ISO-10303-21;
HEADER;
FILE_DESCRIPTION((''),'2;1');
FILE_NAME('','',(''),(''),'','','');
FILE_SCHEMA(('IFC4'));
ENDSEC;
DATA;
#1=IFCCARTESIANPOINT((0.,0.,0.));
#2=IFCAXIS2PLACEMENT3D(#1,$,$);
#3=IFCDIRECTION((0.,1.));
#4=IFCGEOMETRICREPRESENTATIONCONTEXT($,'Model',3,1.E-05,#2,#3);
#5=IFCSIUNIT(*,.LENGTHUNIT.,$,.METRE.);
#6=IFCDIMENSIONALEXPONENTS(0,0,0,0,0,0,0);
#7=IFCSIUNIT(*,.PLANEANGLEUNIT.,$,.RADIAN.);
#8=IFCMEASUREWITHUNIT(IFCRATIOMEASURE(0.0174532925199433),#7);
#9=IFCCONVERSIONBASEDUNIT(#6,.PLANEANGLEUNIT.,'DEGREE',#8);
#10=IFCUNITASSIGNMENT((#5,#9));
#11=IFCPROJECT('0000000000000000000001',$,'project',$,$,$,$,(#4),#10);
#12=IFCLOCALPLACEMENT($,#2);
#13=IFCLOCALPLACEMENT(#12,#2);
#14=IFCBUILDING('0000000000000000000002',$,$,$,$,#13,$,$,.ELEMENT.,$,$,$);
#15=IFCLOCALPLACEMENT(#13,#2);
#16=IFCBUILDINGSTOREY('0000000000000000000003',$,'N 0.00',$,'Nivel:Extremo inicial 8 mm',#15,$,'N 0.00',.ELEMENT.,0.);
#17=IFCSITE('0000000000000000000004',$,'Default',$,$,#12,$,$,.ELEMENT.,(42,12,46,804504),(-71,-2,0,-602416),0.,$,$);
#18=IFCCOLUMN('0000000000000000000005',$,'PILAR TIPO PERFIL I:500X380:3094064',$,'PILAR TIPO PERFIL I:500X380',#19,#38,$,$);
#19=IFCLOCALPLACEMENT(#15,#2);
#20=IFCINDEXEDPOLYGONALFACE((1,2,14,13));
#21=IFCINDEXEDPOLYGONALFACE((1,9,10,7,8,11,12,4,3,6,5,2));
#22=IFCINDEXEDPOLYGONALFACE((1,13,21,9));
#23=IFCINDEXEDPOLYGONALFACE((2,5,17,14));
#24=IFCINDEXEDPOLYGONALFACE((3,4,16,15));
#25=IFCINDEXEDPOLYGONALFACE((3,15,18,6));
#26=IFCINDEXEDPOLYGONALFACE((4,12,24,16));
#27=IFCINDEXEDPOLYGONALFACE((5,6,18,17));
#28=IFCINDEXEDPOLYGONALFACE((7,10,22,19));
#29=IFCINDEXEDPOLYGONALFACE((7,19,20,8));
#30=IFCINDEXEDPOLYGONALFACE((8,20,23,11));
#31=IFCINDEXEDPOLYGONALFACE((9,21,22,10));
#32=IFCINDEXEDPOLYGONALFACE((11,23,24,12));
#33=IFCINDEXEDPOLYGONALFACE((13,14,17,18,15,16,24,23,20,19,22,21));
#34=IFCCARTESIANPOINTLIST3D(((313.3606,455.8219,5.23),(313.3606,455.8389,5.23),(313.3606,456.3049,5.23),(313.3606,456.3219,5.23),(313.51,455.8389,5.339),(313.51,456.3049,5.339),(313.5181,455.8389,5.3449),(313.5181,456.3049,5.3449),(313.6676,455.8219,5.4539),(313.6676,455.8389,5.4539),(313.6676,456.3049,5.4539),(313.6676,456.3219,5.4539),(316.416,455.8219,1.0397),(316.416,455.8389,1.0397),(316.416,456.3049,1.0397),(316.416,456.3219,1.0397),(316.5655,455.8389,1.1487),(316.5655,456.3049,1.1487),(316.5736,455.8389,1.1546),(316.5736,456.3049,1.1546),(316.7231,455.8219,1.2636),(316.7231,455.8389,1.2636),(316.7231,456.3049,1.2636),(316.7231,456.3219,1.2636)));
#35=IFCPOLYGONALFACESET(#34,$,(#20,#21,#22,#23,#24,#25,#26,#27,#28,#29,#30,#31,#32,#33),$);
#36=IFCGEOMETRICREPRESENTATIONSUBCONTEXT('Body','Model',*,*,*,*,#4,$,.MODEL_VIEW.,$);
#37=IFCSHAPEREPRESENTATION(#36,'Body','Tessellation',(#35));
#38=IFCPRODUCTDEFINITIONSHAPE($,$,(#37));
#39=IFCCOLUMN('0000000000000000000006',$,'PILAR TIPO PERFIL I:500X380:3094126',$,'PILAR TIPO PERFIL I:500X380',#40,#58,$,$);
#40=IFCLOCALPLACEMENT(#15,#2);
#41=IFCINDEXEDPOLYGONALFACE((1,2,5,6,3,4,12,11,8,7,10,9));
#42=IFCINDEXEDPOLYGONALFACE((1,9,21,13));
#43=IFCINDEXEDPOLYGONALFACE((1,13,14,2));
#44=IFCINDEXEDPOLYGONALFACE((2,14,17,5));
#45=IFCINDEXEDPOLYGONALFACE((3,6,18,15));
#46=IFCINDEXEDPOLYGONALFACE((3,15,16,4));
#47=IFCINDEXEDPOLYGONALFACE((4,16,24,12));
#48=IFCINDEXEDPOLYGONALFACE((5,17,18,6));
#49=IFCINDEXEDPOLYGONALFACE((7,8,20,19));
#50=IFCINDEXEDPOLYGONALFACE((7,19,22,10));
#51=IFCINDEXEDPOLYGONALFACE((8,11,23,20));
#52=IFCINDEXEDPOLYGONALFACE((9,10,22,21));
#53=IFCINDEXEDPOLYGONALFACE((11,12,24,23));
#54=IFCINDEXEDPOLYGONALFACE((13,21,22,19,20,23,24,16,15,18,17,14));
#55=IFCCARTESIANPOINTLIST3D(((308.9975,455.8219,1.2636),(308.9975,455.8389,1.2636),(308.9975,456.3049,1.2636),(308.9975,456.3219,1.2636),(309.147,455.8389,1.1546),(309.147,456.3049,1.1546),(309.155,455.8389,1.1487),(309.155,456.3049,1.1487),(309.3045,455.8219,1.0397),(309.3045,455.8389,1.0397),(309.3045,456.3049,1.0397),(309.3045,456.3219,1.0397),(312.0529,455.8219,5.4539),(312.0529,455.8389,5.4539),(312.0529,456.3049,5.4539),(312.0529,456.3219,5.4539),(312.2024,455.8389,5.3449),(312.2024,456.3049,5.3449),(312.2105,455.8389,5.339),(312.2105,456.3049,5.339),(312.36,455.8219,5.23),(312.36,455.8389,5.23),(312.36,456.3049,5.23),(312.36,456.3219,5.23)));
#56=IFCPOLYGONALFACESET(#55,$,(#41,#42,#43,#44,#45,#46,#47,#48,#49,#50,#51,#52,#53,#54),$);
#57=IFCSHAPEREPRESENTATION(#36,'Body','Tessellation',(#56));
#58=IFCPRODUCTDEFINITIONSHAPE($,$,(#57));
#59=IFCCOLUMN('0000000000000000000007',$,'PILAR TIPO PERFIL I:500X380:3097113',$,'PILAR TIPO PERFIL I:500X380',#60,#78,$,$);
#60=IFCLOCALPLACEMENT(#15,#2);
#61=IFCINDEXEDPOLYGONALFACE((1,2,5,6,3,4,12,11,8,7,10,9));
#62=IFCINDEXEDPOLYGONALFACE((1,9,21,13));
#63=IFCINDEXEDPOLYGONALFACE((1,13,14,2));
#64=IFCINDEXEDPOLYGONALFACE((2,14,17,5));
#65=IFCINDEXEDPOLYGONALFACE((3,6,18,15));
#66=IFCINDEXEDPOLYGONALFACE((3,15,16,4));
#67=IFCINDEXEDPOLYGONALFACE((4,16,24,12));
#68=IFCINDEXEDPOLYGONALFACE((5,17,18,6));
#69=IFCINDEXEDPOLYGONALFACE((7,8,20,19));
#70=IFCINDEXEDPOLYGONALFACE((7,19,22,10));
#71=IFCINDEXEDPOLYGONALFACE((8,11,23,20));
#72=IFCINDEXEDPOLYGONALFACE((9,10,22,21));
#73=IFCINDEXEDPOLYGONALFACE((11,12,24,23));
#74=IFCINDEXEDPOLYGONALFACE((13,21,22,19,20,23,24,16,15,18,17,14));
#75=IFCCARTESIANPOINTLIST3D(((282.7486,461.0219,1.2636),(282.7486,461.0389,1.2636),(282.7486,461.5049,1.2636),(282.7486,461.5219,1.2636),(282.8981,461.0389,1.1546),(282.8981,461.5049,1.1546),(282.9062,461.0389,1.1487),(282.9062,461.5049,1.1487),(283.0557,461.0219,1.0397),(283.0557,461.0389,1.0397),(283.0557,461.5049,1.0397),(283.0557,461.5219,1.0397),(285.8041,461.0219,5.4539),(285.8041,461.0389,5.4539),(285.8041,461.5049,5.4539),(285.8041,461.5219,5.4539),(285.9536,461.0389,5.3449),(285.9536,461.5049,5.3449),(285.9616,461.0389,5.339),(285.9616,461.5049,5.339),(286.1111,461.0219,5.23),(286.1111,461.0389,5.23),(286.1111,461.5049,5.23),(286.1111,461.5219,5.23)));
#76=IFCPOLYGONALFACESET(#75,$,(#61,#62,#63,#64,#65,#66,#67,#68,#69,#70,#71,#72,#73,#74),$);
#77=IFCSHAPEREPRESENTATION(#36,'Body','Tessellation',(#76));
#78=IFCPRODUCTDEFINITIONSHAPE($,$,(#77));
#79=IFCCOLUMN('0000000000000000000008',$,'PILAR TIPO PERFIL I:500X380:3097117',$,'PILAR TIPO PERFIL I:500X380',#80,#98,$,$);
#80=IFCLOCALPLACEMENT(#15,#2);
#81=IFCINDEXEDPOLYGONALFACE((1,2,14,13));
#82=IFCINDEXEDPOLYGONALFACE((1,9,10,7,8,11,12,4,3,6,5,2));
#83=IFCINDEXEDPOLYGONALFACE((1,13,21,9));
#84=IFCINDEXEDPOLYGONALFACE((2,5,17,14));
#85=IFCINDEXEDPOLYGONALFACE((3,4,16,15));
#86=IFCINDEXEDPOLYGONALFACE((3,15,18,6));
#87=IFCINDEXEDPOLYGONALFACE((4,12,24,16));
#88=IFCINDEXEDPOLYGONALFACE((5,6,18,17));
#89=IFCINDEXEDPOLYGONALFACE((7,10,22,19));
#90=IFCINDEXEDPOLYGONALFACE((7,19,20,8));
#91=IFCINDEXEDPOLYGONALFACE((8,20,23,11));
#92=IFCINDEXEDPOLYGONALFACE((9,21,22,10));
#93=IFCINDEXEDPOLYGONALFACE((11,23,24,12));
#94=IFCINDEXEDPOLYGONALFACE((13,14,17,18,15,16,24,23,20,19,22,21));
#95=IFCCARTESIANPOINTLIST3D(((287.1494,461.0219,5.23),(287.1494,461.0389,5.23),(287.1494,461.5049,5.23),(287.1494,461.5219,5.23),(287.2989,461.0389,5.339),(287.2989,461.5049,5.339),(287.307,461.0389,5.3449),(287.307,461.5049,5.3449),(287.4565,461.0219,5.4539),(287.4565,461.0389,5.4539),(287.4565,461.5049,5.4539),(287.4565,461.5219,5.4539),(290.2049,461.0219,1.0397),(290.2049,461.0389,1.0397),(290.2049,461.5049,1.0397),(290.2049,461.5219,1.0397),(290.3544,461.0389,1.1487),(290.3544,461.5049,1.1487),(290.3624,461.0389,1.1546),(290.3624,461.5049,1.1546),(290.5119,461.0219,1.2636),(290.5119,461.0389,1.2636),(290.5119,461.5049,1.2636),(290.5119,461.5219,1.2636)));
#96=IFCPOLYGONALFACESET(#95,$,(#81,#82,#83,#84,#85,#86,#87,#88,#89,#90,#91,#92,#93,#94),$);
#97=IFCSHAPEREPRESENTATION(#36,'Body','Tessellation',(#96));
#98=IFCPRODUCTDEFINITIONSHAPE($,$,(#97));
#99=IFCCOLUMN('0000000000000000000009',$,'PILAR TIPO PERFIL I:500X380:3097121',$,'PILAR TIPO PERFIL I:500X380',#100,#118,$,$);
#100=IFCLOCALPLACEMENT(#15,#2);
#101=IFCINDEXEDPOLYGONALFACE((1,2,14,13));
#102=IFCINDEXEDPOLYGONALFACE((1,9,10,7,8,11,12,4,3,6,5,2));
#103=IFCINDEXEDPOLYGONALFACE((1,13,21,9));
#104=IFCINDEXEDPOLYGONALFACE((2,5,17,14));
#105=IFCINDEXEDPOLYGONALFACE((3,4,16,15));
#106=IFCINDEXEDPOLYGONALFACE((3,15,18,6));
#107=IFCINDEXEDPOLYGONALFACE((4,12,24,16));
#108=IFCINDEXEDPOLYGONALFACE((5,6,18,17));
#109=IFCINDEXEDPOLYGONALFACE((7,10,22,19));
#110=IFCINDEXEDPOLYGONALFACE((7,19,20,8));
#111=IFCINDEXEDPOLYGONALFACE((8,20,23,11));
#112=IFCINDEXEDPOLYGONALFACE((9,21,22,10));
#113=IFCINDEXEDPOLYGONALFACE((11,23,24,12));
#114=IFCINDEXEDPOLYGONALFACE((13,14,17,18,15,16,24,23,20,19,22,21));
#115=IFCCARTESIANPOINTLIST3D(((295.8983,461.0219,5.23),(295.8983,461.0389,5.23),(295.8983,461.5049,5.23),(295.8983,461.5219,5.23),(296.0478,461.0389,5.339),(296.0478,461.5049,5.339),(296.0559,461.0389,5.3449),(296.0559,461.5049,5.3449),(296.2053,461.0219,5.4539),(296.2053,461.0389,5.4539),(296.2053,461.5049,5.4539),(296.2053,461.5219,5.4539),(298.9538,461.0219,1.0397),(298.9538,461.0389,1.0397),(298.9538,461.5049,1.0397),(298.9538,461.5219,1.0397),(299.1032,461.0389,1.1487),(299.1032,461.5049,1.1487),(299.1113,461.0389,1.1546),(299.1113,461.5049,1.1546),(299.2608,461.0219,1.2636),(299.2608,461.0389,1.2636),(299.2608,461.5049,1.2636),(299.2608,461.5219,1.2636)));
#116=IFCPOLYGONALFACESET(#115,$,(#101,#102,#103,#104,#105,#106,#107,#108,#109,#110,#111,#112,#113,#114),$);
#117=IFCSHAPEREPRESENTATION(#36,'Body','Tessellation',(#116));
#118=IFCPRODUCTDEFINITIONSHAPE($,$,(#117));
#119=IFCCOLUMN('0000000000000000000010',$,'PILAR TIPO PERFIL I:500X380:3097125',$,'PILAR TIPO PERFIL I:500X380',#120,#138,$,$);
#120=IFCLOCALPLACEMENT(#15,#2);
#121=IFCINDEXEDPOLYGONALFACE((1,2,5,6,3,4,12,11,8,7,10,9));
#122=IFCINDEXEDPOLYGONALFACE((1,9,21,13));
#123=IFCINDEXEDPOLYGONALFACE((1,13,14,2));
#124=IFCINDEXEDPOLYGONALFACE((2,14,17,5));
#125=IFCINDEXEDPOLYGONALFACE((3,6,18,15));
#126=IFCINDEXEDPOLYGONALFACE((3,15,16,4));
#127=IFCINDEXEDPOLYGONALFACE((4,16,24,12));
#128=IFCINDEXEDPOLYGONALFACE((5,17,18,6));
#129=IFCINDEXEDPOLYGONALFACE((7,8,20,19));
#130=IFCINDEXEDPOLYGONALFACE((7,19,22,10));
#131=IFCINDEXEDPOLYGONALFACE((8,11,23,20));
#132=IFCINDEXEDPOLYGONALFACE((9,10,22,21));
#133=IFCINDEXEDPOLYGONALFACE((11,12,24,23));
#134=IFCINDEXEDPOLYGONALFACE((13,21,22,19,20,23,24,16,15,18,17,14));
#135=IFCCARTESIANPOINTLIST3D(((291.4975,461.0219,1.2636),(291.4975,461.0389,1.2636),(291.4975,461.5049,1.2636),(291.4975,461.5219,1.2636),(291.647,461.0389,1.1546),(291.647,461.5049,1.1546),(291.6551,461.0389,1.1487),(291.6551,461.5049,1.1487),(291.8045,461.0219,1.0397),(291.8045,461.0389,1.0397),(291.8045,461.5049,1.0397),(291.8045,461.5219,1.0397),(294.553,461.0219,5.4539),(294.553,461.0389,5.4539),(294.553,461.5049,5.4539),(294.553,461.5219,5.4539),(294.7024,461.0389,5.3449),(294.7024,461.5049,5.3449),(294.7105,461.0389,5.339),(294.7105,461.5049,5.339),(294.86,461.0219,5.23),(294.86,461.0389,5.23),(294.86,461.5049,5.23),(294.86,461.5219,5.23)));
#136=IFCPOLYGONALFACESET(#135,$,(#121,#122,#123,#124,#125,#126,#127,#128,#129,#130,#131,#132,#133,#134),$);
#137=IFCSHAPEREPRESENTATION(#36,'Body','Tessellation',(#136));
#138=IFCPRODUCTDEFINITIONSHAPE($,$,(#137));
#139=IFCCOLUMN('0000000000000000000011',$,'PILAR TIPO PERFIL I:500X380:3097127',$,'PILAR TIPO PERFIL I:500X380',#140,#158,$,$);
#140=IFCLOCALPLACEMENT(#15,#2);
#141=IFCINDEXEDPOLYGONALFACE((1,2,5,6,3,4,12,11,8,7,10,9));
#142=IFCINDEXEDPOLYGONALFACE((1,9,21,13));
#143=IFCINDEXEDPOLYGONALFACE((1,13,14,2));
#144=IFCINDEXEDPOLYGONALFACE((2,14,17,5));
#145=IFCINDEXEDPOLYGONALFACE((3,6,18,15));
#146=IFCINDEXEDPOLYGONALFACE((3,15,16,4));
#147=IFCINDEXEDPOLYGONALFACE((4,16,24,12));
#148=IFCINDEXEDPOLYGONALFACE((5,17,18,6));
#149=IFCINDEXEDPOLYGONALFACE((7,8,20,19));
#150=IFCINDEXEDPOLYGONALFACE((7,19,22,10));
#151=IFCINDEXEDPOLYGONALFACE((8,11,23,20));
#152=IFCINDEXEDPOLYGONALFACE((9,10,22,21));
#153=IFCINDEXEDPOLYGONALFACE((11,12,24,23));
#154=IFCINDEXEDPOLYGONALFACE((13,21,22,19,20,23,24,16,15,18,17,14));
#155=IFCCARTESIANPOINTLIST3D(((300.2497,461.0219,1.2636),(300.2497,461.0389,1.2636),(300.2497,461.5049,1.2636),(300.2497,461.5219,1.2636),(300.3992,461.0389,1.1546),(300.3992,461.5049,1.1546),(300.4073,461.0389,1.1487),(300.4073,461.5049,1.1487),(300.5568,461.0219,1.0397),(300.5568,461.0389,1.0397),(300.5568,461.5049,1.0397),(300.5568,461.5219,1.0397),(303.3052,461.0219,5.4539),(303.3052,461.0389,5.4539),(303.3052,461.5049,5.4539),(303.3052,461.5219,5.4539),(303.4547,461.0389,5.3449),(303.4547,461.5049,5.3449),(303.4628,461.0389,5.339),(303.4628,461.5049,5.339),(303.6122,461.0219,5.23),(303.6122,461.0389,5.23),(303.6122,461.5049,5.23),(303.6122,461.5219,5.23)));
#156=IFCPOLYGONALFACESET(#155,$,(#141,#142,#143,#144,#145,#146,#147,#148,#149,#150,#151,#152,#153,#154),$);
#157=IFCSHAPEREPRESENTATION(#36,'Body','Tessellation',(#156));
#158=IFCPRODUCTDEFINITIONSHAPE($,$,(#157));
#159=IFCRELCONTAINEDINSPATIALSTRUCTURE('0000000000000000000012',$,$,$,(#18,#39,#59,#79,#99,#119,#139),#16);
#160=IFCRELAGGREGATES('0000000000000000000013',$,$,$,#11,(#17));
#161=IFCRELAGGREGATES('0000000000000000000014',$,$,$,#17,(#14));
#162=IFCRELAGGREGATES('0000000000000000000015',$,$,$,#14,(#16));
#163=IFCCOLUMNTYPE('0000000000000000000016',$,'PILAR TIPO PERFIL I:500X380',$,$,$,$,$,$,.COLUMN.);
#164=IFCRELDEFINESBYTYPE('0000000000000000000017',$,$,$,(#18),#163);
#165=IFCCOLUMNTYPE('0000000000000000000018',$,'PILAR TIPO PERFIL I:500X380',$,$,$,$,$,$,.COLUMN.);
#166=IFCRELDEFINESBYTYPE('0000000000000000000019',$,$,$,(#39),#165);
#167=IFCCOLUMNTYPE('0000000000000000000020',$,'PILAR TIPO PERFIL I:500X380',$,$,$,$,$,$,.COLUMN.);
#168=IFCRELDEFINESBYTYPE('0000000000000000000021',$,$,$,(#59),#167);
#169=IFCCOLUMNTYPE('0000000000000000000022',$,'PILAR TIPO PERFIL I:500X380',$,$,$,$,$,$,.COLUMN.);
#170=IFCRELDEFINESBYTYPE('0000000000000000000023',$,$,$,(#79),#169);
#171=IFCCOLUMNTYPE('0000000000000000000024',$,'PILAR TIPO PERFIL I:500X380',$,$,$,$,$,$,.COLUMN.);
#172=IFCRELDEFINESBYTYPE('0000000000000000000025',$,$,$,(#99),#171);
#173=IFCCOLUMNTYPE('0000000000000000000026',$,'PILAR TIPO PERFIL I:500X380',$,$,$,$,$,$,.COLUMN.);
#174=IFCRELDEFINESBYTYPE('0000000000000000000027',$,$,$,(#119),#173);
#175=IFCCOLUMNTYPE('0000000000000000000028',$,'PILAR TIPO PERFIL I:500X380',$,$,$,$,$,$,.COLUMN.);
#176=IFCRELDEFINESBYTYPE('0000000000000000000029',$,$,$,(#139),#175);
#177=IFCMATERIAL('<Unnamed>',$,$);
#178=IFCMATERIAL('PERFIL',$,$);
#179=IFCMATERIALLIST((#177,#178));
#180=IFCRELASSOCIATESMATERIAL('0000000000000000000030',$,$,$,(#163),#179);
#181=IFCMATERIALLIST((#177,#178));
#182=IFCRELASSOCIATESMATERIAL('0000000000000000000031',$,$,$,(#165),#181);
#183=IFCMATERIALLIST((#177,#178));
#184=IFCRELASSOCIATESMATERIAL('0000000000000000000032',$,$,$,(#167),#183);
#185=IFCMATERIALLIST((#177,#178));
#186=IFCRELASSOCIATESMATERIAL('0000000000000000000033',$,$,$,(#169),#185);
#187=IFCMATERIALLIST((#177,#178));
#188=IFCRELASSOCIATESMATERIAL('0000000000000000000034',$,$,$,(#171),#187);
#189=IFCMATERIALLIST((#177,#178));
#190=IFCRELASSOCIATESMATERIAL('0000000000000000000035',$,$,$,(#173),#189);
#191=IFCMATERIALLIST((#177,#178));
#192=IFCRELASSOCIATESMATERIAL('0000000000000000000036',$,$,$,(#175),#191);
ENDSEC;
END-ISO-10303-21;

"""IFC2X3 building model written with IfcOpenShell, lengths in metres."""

from ifc_helpers import new_model, entity, si_unit, converted_unit, direction, frame, frame_2d, origin, place, context, subcontext, project, spatial, polyline, i_section, outline, extrude, source, transform, mapped, material, material_list, type_object, type_shapes, element, save


model = new_model("IFC2X3")

# Units and contexts
model_context = context("Model", 3, precision=1e-05, world=origin(), true_north=direction((0.0, 1.0)))
body_context = subcontext(model_context, "Body", "Model", "MODEL_VIEW")
ifc_project = project(units=[si_unit("LENGTHUNIT", "METRE"), converted_unit("PLANEANGLEUNIT", "DEGREE", entity("IfcRatioMeasure", 0.0174532925199433), si_unit("PLANEANGLEUNIT", "RADIAN"), dimensions=[0, 0, 0, 0, 0, 0, 0])], contexts=[model_context])

# Site, building, storey
site_placement = place(None, origin())
site = spatial("IfcSite", under=ifc_project, at=site_placement, Name="Default", CompositionType="ELEMENT", RefLatitude=(42, 12, 46, 804504), RefLongitude=(-71, -2, 0, -602416), RefElevation=0.0)
building_placement = place(site_placement, origin())
building = spatial("IfcBuilding", under=site, at=building_placement, CompositionType="ELEMENT")
storey_placement = place(building_placement, origin())
storey = spatial("IfcBuildingStorey", under=building, at=storey_placement, Name="N 0.00", ObjectType="Nivel:Extremo inicial 8 mm", LongName="N 0.00", CompositionType="ELEMENT", Elevation=0.0)

# Columns
ifc_material_1 = material(Name="<Unnamed>")
ifc_material_2 = material(Name="PERFIL")
ifc_material_list_1 = material_list([ifc_material_1, ifc_material_2])
column_type_1 = type_object("IfcColumnType", Name="PILAR TIPO PERFIL I:500X380", PredefinedType="COLUMN", material=ifc_material_list_1)
shared_shape_1 = source(origin(), body_context, "Body", "SweptSolid", [
    extrude(outline(polyline([(0.233, -0.19), (0.25, -0.19), (0.25, 0.19), (0.233, 0.19), (0.233, 0.005), (-0.233, 0.005), (-0.233, 0.19), (-0.25, 0.19), (-0.25, -0.19), (-0.233, -0.19), (-0.233, -0.005), (0.233, -0.005), (0.233, -0.19)])), frame((316.5695, 456.0719, 1.1516), z_axis=(-0.589174, 0.0, 0.808006), x_axis=(0.0, -1.0, 0.0)), (0.0, 0.0, 1.0), 5.186),
])
type_shapes(column_type_1, [shared_shape_1])
column_1_placement = place(storey_placement, origin())
element("IfcColumn", 1, at=column_1_placement, inside=storey, type_object=column_type_1, Name="PILAR TIPO PERFIL I:500X380:3094064", ObjectType="PILAR TIPO PERFIL I:500X380", context=body_context, shape_type="MappedRepresentation", body=[
    mapped(shared_shape_1, transform((0.0, 0.0, 0.0), scale=1.0)),
])
ifc_material_list_2 = material_list([ifc_material_1, ifc_material_2])
column_type_2 = type_object("IfcColumnType", Name="PILAR TIPO PERFIL I:500X380", PredefinedType="COLUMN", material=ifc_material_list_2)
shared_shape_2 = source(origin(), body_context, "Body", "SweptSolid", [
    extrude(outline(polyline([(0.233, -0.19), (0.25, -0.19), (0.25, 0.19), (0.233, 0.19), (0.233, 0.005), (-0.233, 0.005), (-0.233, 0.19), (-0.25, 0.19), (-0.25, -0.19), (-0.233, -0.19), (-0.233, -0.005), (0.233, -0.005), (0.233, -0.19)])), frame((309.151, 456.0719, 1.1516), z_axis=(0.589174, 0.0, 0.808006), x_axis=(0.0, -1.0, 0.0)), (0.0, 0.0, 1.0), 5.186),
])
type_shapes(column_type_2, [shared_shape_2])
column_2_placement = place(storey_placement, origin())
element("IfcColumn", 2, at=column_2_placement, inside=storey, type_object=column_type_2, Name="PILAR TIPO PERFIL I:500X380:3094126", ObjectType="PILAR TIPO PERFIL I:500X380", context=body_context, shape_type="MappedRepresentation", body=[
    mapped(shared_shape_2, transform((0.0, 0.0, 0.0), scale=1.0)),
])
ifc_material_list_3 = material_list([ifc_material_1, ifc_material_2])
column_type_3 = type_object("IfcColumnType", Name="PILAR TIPO PERFIL I:500X380", PredefinedType="COLUMN", material=ifc_material_list_3)
shared_shape_3 = source(origin(), body_context, "Body", "SweptSolid", [
    extrude(i_section(OverallWidth=0.38, OverallDepth=0.5, WebThickness=0.01, FlangeThickness=0.017, at=frame_2d((0.0, 0.0), x_axis=(0.0, 1.0))), frame((282.9021, 461.2719, 1.1516), z_axis=(0.589174, 0.0, 0.808006), x_axis=(0.0, -1.0, 0.0)), (0.0, 0.0, 1.0), 5.186),
])
type_shapes(column_type_3, [shared_shape_3])
column_3_placement = place(storey_placement, origin())
element("IfcColumn", 3, at=column_3_placement, inside=storey, type_object=column_type_3, Name="PILAR TIPO PERFIL I:500X380:3097113", ObjectType="PILAR TIPO PERFIL I:500X380", context=body_context, shape_type="MappedRepresentation", body=[
    mapped(shared_shape_3, transform((0.0, 0.0, 0.0), scale=1.0)),
])
ifc_material_list_4 = material_list([ifc_material_1, ifc_material_2])
column_type_4 = type_object("IfcColumnType", Name="PILAR TIPO PERFIL I:500X380", PredefinedType="COLUMN", material=ifc_material_list_4)
shared_shape_4 = source(origin(), body_context, "Body", "SweptSolid", [
    extrude(i_section(OverallWidth=0.38, OverallDepth=0.5, WebThickness=0.01, FlangeThickness=0.017, at=frame_2d((0.0, 0.0), x_axis=(0.0, 1.0))), frame((290.3584, 461.2719, 1.1516), z_axis=(-0.589174, 0.0, 0.808006), x_axis=(0.0, -1.0, 0.0)), (0.0, 0.0, 1.0), 5.186),
])
type_shapes(column_type_4, [shared_shape_4])
column_4_placement = place(storey_placement, origin())
element("IfcColumn", 4, at=column_4_placement, inside=storey, type_object=column_type_4, Name="PILAR TIPO PERFIL I:500X380:3097117", ObjectType="PILAR TIPO PERFIL I:500X380", context=body_context, shape_type="MappedRepresentation", body=[
    mapped(shared_shape_4, transform((0.0, 0.0, 0.0), scale=1.0)),
])
ifc_material_list_5 = material_list([ifc_material_1, ifc_material_2])
column_type_5 = type_object("IfcColumnType", Name="PILAR TIPO PERFIL I:500X380", PredefinedType="COLUMN", material=ifc_material_list_5)
shared_shape_5 = source(origin(), body_context, "Body", "SweptSolid", [
    extrude(i_section(OverallWidth=0.38, OverallDepth=0.5, WebThickness=0.01, FlangeThickness=0.017, at=frame_2d((0.0, 0.0), x_axis=(0.0, 1.0))), frame((299.1073, 461.2719, 1.1516), z_axis=(-0.589174, 0.0, 0.808006), x_axis=(0.0, -1.0, 0.0)), (0.0, 0.0, 1.0), 5.186),
])
type_shapes(column_type_5, [shared_shape_5])
column_5_placement = place(storey_placement, origin())
element("IfcColumn", 5, at=column_5_placement, inside=storey, type_object=column_type_5, Name="PILAR TIPO PERFIL I:500X380:3097121", ObjectType="PILAR TIPO PERFIL I:500X380", context=body_context, shape_type="MappedRepresentation", body=[
    mapped(shared_shape_5, transform((0.0, 0.0, 0.0), scale=1.0)),
])
ifc_material_list_6 = material_list([ifc_material_1, ifc_material_2])
column_type_6 = type_object("IfcColumnType", Name="PILAR TIPO PERFIL I:500X380", PredefinedType="COLUMN", material=ifc_material_list_6)
shared_shape_6 = source(origin(), body_context, "Body", "SweptSolid", [
    extrude(i_section(OverallWidth=0.38, OverallDepth=0.5, WebThickness=0.01, FlangeThickness=0.017, at=frame_2d((0.0, 0.0), x_axis=(0.0, 1.0))), frame((291.651, 461.2719, 1.1516), z_axis=(0.589174, 0.0, 0.808006), x_axis=(0.0, -1.0, 0.0)), (0.0, 0.0, 1.0), 5.186),
])
type_shapes(column_type_6, [shared_shape_6])
column_6_placement = place(storey_placement, origin())
element("IfcColumn", 6, at=column_6_placement, inside=storey, type_object=column_type_6, Name="PILAR TIPO PERFIL I:500X380:3097125", ObjectType="PILAR TIPO PERFIL I:500X380", context=body_context, shape_type="MappedRepresentation", body=[
    mapped(shared_shape_6, transform((0.0, 0.0, 0.0), scale=1.0)),
])
ifc_material_list_7 = material_list([ifc_material_1, ifc_material_2])
column_type_7 = type_object("IfcColumnType", Name="PILAR TIPO PERFIL I:500X380", PredefinedType="COLUMN", material=ifc_material_list_7)
shared_shape_7 = source(origin(), body_context, "Body", "SweptSolid", [
    extrude(i_section(OverallWidth=0.38, OverallDepth=0.5, WebThickness=0.01, FlangeThickness=0.017, at=frame_2d((0.0, 0.0), x_axis=(0.0, 1.0))), frame((300.4033, 461.2719, 1.1516), z_axis=(0.589174, 0.0, 0.808006), x_axis=(0.0, -1.0, 0.0)), (0.0, 0.0, 1.0), 5.186),
])
type_shapes(column_type_7, [shared_shape_7])
column_7_placement = place(storey_placement, origin())
element("IfcColumn", 7, at=column_7_placement, inside=storey, type_object=column_type_7, Name="PILAR TIPO PERFIL I:500X380:3097127", ObjectType="PILAR TIPO PERFIL I:500X380", context=body_context, shape_type="MappedRepresentation", body=[
    mapped(shared_shape_7, transform((0.0, 0.0, 0.0), scale=1.0)),
])

save(model, "model.ifc")
